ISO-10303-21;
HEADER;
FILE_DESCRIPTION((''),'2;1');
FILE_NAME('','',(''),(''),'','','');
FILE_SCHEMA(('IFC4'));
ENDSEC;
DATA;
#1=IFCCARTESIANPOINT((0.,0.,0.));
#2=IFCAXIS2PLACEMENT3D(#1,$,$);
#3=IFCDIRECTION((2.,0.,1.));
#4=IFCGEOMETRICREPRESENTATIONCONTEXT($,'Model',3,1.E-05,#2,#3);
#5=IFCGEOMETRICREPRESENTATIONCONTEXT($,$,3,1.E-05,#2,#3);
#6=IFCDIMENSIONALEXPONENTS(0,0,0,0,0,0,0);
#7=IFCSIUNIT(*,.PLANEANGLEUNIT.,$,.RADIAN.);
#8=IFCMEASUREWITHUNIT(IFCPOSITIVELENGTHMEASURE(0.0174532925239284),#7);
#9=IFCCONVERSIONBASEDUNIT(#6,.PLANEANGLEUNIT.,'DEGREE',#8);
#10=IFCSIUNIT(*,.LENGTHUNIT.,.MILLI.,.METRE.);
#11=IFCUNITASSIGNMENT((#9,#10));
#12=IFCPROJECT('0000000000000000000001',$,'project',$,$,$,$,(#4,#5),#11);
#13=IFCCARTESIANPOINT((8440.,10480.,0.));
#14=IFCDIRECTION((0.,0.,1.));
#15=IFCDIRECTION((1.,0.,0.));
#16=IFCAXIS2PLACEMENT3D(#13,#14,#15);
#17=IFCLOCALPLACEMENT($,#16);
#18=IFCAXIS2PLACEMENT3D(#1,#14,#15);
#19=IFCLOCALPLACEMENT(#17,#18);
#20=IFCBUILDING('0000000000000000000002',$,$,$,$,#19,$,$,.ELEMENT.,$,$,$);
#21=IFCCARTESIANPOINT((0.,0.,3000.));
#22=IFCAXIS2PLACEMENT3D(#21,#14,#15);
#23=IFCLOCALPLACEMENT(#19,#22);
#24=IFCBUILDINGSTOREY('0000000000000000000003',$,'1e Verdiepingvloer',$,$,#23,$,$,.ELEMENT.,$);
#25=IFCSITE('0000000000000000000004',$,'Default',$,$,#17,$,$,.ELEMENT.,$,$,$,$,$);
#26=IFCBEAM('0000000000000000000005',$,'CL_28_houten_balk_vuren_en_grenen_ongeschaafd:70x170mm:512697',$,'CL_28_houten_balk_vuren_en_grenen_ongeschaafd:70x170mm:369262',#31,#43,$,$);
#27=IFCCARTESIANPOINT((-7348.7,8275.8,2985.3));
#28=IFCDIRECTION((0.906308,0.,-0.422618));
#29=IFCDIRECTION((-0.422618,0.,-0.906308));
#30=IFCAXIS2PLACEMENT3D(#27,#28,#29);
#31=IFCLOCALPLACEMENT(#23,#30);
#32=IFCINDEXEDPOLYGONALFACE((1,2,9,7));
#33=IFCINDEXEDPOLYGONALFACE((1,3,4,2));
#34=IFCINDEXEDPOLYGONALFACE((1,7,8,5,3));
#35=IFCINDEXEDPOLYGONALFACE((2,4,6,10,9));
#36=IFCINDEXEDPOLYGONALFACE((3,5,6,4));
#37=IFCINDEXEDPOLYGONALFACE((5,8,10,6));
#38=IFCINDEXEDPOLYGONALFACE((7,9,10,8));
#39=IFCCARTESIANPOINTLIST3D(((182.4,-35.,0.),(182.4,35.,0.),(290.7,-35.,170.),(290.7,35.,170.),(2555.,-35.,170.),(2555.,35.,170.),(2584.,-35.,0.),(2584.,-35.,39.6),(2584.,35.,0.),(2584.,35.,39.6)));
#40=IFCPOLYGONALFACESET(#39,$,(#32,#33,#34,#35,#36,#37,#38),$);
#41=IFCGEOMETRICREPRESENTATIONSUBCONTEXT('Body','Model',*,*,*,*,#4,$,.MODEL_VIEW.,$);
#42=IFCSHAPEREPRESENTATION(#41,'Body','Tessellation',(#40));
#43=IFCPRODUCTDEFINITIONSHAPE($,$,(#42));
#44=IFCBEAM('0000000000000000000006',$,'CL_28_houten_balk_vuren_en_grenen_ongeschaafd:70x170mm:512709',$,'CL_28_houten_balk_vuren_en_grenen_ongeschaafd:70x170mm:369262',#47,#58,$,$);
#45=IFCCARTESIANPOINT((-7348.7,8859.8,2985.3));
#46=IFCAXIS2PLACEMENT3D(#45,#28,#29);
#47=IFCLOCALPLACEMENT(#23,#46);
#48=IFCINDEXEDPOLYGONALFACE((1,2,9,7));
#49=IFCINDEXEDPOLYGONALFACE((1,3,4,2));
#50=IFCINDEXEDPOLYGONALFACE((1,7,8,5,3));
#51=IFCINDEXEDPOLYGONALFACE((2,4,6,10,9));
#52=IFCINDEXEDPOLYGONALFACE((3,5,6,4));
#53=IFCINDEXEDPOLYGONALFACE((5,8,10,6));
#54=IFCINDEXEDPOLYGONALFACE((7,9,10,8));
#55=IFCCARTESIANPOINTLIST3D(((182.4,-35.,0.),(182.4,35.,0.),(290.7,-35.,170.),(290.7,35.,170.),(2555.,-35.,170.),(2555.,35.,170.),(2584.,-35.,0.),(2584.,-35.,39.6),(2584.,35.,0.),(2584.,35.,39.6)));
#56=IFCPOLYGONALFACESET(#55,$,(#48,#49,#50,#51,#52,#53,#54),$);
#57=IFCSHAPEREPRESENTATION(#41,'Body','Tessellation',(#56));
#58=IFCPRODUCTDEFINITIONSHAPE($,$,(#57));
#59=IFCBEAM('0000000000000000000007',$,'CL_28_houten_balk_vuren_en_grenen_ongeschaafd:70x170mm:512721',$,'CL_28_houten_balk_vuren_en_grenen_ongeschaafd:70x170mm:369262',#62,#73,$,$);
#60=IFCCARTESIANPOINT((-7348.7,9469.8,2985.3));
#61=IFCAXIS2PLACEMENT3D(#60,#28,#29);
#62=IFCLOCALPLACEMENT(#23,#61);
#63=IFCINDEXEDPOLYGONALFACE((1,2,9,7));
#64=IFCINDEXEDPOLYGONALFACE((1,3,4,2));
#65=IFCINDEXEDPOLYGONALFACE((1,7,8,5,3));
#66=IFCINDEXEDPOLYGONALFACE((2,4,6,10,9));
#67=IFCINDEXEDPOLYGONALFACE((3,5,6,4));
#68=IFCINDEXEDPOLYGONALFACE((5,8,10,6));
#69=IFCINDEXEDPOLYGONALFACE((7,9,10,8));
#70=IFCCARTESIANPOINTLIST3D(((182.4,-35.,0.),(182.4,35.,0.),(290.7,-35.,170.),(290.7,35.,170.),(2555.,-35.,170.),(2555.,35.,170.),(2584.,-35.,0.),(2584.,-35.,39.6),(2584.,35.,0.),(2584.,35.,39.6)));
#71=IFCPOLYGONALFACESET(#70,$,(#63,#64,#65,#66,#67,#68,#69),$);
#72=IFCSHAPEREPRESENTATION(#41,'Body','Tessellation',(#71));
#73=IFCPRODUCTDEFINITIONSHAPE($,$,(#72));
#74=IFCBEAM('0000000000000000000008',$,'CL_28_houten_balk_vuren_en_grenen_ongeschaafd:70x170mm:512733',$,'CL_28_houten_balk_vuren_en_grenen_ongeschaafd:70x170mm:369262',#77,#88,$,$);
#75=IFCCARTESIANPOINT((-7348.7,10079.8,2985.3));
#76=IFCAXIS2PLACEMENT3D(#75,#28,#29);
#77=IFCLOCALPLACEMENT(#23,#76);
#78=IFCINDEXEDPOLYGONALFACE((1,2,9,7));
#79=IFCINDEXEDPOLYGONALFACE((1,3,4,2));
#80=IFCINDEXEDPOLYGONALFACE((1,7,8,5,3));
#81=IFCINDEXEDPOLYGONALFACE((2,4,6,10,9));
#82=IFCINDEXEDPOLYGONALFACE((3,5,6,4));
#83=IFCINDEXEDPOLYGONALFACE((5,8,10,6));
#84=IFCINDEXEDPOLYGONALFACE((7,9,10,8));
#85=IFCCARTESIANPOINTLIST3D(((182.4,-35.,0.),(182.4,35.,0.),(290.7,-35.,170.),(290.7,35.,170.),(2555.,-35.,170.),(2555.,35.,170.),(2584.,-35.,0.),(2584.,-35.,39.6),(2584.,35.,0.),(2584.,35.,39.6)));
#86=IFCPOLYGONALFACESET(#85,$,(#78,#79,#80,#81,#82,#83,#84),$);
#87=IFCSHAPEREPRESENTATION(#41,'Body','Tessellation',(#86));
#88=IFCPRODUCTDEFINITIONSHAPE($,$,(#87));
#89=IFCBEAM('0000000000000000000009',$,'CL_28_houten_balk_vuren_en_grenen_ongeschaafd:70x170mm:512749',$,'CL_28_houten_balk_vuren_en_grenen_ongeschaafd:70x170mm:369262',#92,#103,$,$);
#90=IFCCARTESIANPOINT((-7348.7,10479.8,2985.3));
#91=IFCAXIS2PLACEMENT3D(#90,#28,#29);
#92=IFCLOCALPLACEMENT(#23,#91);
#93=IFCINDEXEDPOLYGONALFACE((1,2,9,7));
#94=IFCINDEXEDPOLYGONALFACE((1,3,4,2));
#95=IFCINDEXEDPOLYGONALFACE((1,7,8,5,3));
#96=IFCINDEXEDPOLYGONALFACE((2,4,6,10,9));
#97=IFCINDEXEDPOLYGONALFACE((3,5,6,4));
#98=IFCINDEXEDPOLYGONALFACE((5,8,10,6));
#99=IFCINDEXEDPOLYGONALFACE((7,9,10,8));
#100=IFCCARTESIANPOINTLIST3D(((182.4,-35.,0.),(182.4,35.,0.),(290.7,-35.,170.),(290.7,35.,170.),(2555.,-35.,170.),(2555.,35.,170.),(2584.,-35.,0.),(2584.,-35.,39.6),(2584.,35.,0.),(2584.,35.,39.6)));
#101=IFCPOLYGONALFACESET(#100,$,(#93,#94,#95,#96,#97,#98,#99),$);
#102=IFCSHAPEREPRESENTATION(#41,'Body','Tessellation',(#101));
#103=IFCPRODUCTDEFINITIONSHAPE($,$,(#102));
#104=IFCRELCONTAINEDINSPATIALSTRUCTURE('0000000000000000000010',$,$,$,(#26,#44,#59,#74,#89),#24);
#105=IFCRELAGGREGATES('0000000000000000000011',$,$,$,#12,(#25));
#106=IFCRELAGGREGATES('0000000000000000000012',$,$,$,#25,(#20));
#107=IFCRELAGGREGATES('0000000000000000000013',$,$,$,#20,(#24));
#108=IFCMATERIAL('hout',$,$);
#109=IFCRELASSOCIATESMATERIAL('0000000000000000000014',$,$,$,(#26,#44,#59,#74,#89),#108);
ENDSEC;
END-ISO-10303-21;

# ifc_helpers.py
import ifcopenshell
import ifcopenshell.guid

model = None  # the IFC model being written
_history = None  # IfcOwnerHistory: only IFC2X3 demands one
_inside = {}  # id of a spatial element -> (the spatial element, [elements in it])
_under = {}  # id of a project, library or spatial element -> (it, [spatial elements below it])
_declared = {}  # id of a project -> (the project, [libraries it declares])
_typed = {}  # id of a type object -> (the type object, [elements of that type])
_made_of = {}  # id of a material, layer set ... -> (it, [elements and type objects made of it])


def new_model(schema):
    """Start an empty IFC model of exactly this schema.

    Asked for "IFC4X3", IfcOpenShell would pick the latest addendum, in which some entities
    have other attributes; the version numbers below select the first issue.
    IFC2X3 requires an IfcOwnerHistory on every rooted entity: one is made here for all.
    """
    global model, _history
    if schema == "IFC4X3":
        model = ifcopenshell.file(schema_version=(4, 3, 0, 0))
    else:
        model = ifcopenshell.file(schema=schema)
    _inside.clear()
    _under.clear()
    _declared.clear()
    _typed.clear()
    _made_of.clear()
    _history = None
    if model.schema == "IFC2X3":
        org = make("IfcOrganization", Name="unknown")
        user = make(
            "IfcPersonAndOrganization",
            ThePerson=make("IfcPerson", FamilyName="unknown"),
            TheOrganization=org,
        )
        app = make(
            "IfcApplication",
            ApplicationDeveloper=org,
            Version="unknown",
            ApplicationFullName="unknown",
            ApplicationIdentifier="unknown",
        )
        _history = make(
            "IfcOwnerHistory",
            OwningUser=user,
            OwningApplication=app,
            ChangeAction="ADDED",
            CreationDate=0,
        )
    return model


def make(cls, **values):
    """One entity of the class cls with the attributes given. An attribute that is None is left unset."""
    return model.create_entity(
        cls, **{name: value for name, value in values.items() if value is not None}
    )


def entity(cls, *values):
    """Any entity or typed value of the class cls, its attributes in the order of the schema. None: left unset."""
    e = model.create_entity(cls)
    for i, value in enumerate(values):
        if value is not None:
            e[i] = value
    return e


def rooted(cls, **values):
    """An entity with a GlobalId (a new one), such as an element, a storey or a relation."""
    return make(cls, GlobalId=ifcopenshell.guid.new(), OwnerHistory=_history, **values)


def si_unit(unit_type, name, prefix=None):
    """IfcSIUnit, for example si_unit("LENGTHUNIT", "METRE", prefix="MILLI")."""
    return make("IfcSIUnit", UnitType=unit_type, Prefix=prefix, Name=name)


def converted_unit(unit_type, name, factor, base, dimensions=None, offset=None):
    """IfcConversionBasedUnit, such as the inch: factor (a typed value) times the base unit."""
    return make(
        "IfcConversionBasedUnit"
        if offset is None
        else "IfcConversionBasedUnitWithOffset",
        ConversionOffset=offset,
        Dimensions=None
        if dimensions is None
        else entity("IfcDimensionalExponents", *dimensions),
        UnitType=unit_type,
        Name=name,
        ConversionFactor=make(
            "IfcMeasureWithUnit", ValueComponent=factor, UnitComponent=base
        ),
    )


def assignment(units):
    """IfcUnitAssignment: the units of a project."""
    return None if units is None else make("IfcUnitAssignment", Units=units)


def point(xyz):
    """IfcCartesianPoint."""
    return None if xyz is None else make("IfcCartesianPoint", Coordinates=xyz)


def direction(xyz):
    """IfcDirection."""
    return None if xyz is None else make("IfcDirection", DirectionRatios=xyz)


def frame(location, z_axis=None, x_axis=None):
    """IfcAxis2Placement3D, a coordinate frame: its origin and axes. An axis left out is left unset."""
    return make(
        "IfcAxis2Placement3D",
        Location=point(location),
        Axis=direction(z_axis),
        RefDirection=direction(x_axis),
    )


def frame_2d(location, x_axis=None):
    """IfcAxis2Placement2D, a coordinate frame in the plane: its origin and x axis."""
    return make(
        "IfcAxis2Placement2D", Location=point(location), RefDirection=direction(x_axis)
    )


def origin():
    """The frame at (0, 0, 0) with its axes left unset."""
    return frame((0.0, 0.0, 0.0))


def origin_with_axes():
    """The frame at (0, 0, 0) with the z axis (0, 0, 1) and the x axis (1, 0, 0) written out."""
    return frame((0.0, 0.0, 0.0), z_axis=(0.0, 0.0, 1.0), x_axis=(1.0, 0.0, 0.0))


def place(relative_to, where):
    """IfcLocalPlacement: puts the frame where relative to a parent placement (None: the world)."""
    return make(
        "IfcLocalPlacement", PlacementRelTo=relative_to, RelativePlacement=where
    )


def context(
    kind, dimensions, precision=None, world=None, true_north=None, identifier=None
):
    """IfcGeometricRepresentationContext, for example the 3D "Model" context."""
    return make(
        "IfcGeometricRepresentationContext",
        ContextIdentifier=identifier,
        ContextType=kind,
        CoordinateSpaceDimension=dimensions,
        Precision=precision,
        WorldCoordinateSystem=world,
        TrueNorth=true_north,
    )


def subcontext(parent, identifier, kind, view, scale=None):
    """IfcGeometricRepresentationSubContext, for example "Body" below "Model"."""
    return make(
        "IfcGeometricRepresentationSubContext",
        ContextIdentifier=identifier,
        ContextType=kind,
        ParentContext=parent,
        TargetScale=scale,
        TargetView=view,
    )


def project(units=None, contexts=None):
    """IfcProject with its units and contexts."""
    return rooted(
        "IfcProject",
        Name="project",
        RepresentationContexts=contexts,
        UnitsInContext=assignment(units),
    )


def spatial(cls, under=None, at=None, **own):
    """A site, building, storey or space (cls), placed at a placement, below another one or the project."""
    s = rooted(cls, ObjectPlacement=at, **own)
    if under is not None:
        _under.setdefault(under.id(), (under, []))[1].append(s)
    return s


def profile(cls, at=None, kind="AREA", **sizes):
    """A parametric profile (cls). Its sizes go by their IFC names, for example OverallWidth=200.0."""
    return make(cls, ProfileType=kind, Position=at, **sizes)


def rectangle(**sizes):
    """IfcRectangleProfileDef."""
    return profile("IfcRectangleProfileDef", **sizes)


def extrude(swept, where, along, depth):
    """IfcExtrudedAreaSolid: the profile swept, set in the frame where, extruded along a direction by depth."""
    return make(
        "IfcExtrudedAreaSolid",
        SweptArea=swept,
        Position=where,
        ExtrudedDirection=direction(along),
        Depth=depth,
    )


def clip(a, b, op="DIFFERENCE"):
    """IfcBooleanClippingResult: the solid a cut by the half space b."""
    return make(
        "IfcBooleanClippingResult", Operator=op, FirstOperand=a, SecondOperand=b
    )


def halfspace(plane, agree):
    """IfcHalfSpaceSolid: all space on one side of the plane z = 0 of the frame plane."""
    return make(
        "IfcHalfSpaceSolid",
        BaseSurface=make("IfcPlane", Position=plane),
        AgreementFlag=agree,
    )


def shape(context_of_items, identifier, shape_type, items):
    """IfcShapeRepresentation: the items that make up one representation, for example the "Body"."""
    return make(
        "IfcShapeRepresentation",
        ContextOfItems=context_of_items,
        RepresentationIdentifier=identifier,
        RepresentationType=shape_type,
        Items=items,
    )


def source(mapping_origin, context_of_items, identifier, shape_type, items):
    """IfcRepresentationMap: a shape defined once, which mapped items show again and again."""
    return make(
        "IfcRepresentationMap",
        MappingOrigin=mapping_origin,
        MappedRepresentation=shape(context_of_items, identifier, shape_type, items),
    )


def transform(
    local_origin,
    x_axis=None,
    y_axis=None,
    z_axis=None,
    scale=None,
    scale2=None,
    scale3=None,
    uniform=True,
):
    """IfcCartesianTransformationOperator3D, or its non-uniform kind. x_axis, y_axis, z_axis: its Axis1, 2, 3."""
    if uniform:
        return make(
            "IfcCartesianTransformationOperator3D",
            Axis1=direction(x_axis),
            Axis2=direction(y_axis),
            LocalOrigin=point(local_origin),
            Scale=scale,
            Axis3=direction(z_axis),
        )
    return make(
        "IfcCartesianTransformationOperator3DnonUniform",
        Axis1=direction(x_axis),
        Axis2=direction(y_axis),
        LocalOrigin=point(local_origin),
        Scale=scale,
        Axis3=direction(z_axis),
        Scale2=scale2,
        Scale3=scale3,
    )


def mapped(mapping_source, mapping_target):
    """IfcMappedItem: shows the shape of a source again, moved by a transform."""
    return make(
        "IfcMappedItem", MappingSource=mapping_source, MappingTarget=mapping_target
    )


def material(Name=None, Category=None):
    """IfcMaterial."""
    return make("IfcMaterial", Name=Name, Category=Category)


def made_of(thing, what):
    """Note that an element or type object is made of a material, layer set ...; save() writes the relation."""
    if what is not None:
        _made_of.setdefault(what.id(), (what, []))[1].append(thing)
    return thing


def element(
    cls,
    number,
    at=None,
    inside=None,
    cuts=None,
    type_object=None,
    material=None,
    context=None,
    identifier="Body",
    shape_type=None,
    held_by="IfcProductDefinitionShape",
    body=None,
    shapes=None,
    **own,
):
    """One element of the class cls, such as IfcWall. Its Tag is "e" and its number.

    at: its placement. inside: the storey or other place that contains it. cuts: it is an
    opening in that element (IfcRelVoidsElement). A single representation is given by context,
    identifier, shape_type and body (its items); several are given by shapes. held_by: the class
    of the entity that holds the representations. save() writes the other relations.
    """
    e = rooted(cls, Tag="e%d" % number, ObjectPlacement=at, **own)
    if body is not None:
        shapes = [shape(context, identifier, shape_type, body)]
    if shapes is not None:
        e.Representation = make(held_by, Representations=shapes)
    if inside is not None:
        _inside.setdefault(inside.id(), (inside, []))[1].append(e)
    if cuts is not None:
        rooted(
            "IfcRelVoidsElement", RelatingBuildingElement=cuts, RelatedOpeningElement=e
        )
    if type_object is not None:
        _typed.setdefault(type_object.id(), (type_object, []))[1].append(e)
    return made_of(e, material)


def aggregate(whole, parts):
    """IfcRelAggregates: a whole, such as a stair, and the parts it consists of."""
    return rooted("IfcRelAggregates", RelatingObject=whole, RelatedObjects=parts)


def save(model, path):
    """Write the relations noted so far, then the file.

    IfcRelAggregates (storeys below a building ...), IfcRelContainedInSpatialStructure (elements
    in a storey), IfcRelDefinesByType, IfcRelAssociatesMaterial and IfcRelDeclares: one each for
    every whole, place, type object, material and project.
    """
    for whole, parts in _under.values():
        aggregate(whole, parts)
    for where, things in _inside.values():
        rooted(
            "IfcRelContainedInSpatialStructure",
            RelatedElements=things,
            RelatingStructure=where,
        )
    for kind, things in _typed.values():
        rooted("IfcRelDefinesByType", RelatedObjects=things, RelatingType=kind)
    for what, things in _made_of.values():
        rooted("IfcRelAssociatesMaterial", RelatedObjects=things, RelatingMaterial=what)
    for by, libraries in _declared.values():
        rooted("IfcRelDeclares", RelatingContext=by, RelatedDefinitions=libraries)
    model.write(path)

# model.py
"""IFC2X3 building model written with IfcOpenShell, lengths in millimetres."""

from ifc_helpers import new_model, entity, si_unit, converted_unit, direction, frame, frame_2d, origin, origin_with_axes, place, context, subcontext, project, spatial, rectangle, extrude, clip, halfspace, source, transform, mapped, material, element, save


model = new_model("IFC2X3")

# Units and contexts
model_context = context("Model", 3, precision=1e-05, world=origin(), true_north=direction((2.0, 0.0, 1.0)))
context_of_model = context(None, 3, precision=1e-05, world=origin(), true_north=direction((2.0, 0.0, 1.0)))
body_context = subcontext(model_context, "Body", "Model", "MODEL_VIEW")
ifc_project = project(units=[converted_unit("PLANEANGLEUNIT", "DEGREE", entity("IfcPositiveLengthMeasure", 0.0174532925239284), si_unit("PLANEANGLEUNIT", "RADIAN"), dimensions=[0, 0, 0, 0, 0, 0, 0]), si_unit("LENGTHUNIT", "METRE", prefix="MILLI")], contexts=[model_context, context_of_model])

# Site, building, storey
site_placement = place(None, frame((8440.0, 10480.0, 0.0), z_axis=(0.0, 0.0, 1.0), x_axis=(1.0, 0.0, 0.0)))
site = spatial("IfcSite", under=ifc_project, at=site_placement, Name="Default", CompositionType="ELEMENT")
building_placement = place(site_placement, origin_with_axes())
building = spatial("IfcBuilding", under=site, at=building_placement, CompositionType="ELEMENT")
storey_placement = place(building_placement, frame((0.0, 0.0, 3000.0), z_axis=(0.0, 0.0, 1.0), x_axis=(1.0, 0.0, 0.0)))
storey = spatial("IfcBuildingStorey", under=building, at=storey_placement, Name="1e Verdiepingvloer", CompositionType="ELEMENT")

# Beams
ifc_material_1 = material(Name="hout")
shared_shape_1 = source(origin(), body_context, "Body", "Clipping", [
    clip(clip(extrude(rectangle(XDim=170.0, YDim=70.0, at=frame_2d((0.0, 0.0), x_axis=(0.0, 1.0))), frame((182.4, 0.0, 85.0), z_axis=(1.0, 0.0, 0.0), x_axis=(0.0, 1.0, 0.0)), (0.0, 0.0, 1.0), 2401.5), halfspace(frame((2590.9, -1982.2, 8.5), z_axis=(0.976296, 0.0, 0.21644), x_axis=(-0.21644, 0.0, 0.976296)), False)), halfspace(frame((290.7, -683.2, 170.0), z_axis=(-0.843391, 0.0, 0.5373), x_axis=(0.5373, 0.0, 0.843391)), False)),
])
for number, where, z_axis, x_axis, name in (
    (1, (-7348.7, 8275.8, 2985.3), (0.906308, 0.0, -0.422618), (-0.422618, 0.0, -0.906308), "CL_28_houten_balk_vuren_en_grenen_ongeschaafd:70x170mm:512697"),
    (2, (-7348.7, 8859.8, 2985.3), (0.906308, 0.0, -0.422618), (-0.422618, 0.0, -0.906308), "CL_28_houten_balk_vuren_en_grenen_ongeschaafd:70x170mm:512709"),
    (3, (-7348.7, 9469.8, 2985.3), (0.906308, 0.0, -0.422618), (-0.422618, 0.0, -0.906308), "CL_28_houten_balk_vuren_en_grenen_ongeschaafd:70x170mm:512721"),
    (4, (-7348.7, 10079.8, 2985.3), (0.906308, 0.0, -0.422618), (-0.422618, 0.0, -0.906308), "CL_28_houten_balk_vuren_en_grenen_ongeschaafd:70x170mm:512733"),
    (5, (-7348.7, 10479.8, 2985.3), (0.906308, 0.0, -0.422618), (-0.422618, 0.0, -0.906308), "CL_28_houten_balk_vuren_en_grenen_ongeschaafd:70x170mm:512749"),
):
    element("IfcBeam", number, at=place(storey_placement, frame(where, z_axis=z_axis, x_axis=x_axis)), inside=storey, material=ifc_material_1, Name=name, ObjectType="CL_28_houten_balk_vuren_en_grenen_ongeschaafd:70x170mm:369262", context=body_context, shape_type="MappedRepresentation", body=[
        mapped(shared_shape_1, transform((0.0, 0.0, 0.0))),
    ])

save(model, "model.ifc")
